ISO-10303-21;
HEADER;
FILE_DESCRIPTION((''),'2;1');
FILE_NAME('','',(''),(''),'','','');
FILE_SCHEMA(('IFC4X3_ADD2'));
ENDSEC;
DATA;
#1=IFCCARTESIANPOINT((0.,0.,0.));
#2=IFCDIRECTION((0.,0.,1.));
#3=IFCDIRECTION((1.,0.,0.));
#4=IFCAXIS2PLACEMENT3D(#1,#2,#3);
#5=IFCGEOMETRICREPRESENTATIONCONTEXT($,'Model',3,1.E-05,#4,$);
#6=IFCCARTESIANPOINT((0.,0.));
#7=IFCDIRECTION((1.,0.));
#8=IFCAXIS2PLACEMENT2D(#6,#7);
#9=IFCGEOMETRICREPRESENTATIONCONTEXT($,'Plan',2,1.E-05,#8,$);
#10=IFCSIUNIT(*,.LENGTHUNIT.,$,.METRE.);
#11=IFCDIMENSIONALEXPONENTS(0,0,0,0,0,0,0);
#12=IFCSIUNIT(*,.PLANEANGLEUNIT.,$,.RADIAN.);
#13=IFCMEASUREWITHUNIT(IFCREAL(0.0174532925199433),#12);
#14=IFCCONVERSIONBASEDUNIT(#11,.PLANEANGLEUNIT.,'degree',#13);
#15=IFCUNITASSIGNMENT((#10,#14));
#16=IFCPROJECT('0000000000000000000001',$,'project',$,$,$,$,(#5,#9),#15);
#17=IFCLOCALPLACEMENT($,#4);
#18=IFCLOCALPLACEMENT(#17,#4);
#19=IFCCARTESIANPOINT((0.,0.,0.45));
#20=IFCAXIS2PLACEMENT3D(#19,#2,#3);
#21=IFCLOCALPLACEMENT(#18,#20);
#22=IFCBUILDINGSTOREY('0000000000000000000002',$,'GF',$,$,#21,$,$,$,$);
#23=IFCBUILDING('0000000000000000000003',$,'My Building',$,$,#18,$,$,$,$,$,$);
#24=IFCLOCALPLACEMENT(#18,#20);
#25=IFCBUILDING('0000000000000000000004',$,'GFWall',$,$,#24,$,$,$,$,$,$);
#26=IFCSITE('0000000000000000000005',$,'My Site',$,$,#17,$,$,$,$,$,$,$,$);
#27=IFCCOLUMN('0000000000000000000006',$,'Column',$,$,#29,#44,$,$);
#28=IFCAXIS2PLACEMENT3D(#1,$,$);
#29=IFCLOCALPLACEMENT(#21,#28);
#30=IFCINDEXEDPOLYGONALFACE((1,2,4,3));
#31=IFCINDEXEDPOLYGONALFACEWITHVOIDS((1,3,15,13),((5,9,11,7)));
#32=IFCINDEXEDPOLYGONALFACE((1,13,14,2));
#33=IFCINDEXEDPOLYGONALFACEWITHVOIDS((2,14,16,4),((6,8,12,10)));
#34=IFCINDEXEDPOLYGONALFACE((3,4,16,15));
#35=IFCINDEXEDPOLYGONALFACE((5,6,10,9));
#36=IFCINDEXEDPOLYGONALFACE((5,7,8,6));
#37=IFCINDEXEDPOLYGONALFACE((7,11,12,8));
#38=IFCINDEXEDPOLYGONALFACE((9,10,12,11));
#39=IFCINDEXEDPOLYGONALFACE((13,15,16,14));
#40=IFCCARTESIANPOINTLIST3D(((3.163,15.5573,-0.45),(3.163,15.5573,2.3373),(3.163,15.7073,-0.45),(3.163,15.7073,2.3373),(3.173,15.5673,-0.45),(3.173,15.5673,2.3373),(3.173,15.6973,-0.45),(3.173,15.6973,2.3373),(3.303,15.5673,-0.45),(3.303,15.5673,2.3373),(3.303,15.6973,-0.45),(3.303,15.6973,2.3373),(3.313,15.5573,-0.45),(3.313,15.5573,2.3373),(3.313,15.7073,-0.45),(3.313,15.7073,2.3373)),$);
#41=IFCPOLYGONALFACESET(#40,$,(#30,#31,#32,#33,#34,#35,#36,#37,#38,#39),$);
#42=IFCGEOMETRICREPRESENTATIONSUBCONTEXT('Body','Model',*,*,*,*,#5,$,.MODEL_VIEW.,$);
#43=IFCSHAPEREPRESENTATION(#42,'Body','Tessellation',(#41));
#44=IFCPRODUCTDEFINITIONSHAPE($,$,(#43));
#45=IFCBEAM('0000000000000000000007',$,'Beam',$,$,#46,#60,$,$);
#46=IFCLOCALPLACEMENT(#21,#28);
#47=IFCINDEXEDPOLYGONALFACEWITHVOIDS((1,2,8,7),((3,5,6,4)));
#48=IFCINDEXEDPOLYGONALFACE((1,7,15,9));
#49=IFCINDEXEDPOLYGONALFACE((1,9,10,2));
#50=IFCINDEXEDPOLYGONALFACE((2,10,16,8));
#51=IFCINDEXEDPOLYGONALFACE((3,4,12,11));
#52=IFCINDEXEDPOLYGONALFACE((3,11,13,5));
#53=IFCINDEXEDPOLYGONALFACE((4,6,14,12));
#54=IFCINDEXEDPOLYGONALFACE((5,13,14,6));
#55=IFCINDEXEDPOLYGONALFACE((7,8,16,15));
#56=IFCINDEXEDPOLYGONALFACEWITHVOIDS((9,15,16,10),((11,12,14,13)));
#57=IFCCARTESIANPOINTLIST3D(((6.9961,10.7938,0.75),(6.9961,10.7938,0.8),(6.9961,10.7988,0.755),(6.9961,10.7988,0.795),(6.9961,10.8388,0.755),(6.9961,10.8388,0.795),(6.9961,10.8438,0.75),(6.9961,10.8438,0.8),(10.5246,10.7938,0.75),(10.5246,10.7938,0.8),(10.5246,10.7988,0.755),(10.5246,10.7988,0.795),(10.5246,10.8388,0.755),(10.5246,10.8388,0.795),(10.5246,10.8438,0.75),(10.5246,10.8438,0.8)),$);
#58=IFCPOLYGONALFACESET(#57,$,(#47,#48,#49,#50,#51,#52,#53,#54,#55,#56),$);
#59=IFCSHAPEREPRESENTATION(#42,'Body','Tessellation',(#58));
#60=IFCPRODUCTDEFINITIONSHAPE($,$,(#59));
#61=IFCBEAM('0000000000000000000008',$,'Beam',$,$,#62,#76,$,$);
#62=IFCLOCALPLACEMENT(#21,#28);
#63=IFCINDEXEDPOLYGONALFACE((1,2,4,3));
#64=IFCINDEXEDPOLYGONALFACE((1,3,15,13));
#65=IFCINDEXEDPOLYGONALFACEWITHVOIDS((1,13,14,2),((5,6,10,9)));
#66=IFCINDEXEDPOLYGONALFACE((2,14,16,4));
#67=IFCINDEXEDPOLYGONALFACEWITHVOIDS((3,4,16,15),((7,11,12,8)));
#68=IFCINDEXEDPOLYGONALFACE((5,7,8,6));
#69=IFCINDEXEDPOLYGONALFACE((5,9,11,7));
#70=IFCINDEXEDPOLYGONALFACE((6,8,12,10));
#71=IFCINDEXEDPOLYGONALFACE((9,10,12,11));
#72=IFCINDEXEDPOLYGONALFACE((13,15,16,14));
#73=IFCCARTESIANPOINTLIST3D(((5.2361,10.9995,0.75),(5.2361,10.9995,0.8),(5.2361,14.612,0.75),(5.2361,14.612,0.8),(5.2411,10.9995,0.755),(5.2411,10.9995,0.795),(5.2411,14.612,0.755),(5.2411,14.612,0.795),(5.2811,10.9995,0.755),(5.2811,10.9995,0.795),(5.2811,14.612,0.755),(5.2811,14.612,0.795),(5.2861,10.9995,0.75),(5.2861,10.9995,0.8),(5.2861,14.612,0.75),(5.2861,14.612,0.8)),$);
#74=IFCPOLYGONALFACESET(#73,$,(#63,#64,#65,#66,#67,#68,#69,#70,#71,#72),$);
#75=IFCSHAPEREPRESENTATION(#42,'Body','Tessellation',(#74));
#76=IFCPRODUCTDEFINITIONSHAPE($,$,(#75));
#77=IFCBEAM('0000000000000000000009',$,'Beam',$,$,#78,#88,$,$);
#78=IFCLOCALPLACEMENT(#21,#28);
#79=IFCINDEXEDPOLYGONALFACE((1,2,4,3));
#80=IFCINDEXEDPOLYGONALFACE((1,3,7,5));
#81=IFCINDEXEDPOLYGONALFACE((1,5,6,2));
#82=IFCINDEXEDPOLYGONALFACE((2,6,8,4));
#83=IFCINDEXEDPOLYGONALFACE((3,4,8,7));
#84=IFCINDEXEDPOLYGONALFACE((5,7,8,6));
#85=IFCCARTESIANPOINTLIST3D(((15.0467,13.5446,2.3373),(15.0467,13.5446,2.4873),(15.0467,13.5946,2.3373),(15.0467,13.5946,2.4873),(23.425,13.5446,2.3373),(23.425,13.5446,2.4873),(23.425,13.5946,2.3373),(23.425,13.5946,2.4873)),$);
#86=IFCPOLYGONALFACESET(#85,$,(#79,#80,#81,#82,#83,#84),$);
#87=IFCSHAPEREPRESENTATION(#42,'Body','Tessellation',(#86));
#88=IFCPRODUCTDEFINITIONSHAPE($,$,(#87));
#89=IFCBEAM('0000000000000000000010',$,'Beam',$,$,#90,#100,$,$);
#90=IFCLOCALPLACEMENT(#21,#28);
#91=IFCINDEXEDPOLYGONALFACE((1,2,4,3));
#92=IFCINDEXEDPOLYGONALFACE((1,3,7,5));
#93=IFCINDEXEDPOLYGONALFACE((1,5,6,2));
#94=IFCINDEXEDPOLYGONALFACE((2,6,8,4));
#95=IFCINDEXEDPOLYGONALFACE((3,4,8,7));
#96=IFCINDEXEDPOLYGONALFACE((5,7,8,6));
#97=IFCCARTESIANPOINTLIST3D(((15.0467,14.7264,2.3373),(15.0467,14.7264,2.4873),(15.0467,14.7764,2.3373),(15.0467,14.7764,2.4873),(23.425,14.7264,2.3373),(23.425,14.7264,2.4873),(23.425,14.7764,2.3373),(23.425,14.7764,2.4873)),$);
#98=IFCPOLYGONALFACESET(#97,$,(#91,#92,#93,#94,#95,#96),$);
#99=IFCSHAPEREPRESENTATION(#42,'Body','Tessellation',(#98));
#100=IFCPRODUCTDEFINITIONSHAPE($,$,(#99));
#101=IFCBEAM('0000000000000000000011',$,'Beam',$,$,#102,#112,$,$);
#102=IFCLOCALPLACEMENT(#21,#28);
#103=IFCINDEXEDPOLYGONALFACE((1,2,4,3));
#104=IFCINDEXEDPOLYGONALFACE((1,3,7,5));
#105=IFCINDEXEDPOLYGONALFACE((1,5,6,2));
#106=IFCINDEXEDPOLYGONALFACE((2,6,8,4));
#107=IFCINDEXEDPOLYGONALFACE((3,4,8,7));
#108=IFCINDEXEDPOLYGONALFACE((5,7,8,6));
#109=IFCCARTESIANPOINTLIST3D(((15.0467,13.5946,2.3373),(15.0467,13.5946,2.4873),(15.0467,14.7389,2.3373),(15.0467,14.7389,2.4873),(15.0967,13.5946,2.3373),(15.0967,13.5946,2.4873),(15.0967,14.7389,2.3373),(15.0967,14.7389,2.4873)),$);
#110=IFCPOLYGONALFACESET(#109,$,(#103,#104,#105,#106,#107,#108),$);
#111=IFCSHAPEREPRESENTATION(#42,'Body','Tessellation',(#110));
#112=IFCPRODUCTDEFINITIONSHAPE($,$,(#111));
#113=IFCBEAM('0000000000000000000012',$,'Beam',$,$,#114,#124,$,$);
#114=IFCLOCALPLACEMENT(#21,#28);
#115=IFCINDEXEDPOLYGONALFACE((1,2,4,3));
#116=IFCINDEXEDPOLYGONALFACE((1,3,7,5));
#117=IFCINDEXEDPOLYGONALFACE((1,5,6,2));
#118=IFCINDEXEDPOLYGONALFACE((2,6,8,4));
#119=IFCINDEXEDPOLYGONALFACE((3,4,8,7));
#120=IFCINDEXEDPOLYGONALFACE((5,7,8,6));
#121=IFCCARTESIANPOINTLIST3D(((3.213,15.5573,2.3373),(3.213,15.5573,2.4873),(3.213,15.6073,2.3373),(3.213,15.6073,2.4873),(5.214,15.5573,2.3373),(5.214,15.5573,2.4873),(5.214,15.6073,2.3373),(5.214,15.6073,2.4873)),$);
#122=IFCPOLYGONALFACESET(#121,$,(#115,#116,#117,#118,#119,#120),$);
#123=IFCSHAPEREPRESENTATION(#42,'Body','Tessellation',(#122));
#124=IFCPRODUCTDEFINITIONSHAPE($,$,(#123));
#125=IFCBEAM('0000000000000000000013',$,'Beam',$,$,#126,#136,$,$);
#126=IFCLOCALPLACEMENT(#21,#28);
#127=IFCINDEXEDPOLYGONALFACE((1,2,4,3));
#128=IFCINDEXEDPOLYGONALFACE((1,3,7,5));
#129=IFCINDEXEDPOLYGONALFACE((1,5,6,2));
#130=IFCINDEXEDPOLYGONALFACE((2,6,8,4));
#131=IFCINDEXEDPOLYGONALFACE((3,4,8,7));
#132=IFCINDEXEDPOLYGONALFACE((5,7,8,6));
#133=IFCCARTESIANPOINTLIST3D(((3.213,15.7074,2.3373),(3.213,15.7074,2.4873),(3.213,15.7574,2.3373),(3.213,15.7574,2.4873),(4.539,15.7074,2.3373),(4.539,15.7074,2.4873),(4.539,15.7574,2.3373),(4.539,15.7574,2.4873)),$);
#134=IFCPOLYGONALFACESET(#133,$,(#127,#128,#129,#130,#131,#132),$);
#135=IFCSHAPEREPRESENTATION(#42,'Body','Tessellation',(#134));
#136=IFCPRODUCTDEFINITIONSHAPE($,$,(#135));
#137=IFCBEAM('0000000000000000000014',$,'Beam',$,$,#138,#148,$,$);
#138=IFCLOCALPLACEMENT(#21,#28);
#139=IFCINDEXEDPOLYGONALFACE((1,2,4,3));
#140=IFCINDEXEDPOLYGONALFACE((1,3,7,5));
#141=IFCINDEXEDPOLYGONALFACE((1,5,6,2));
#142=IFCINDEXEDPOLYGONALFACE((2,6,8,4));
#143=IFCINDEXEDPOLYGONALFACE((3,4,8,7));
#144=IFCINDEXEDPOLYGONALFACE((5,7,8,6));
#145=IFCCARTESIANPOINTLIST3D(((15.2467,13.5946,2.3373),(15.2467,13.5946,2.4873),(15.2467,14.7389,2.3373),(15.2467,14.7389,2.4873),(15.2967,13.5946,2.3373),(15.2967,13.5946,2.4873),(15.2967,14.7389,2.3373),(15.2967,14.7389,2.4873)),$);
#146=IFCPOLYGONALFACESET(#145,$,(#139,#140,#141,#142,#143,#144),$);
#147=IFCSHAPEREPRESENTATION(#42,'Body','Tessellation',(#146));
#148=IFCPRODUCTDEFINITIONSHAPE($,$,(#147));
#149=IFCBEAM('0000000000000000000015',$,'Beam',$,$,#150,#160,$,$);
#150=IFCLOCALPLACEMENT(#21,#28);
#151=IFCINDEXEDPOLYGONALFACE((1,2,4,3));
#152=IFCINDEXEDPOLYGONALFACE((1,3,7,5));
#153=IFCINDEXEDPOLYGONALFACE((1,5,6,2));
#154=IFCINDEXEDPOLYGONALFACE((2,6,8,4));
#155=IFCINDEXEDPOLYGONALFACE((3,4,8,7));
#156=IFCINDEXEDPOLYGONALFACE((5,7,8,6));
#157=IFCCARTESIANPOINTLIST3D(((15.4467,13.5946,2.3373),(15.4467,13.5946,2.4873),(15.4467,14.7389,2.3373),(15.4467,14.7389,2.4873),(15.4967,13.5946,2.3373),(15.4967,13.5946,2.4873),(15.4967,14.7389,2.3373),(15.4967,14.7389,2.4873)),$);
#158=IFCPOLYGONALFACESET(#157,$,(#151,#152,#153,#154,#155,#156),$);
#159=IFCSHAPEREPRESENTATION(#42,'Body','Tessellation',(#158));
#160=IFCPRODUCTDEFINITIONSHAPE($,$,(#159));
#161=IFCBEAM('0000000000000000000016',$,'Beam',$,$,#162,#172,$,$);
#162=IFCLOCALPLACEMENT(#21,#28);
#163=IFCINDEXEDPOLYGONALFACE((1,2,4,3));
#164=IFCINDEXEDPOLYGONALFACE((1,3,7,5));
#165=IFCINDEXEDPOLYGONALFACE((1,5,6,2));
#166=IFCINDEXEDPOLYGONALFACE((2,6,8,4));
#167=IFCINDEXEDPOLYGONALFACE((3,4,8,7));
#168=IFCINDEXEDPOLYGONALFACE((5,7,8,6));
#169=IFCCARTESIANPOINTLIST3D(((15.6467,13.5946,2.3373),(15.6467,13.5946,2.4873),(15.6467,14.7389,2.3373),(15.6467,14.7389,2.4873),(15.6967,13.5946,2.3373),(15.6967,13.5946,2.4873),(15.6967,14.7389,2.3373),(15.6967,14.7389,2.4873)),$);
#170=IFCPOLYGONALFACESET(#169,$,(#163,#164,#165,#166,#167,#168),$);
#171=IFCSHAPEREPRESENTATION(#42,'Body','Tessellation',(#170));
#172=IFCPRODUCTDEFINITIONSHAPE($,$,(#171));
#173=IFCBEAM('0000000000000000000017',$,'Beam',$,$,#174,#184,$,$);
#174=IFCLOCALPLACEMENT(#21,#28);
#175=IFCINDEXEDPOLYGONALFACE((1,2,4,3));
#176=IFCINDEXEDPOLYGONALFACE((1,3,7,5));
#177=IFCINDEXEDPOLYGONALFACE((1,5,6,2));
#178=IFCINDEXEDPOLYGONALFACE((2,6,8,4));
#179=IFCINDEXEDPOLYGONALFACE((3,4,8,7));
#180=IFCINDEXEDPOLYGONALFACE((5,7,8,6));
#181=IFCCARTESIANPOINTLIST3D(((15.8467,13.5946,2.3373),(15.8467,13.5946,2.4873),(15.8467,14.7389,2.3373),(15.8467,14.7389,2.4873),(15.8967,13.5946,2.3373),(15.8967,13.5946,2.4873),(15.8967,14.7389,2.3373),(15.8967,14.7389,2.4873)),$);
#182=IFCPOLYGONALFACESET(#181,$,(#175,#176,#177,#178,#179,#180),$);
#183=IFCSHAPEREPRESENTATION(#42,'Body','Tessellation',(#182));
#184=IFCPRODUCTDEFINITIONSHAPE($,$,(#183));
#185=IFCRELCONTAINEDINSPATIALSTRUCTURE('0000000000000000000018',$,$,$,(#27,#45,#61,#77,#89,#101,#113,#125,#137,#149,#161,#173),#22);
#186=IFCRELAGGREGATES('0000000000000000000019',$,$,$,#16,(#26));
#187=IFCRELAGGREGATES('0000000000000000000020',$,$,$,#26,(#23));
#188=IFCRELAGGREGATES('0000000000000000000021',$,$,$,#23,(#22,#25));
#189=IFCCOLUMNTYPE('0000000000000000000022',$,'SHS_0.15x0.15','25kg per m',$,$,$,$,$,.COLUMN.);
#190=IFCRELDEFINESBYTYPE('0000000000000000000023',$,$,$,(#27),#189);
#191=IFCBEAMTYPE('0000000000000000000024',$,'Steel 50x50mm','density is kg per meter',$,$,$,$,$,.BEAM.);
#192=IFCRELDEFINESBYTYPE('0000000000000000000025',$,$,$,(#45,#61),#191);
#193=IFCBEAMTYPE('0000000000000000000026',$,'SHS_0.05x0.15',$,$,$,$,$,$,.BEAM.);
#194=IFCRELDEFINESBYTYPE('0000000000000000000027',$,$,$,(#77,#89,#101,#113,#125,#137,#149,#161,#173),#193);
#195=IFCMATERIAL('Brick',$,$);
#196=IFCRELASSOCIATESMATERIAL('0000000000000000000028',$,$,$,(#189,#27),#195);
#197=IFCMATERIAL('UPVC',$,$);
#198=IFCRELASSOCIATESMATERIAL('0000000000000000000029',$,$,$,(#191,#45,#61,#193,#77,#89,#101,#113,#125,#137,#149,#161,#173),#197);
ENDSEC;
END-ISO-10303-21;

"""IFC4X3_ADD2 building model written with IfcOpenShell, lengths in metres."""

from ifc_helpers import new_model, entity, si_unit, converted_unit, frame, origin_with_axes, origin_2d_with_axis, place, context, subcontext, project, spatial, rectangle, hollow_rectangle, extrude, shape, material, material_profile, profile_set, profile_usage, type_object, element, save


model = new_model("IFC4X3_ADD2")

# Units and contexts
model_context = context("Model", 3, precision=1e-05, world=origin_with_axes())
plan_context = context("Plan", 2, precision=1e-05, world=origin_2d_with_axis())
body_context_1 = subcontext(model_context, "Body", "Model", "MODEL_VIEW")
body_context_2 = subcontext(plan_context, "Body", "Plan", "PLAN_VIEW")
ifc_project = project(units=[si_unit("LENGTHUNIT", "METRE"), converted_unit("PLANEANGLEUNIT", "degree", entity("IfcReal", 0.0174532925199433), si_unit("PLANEANGLEUNIT", "RADIAN"), dimensions=[0, 0, 0, 0, 0, 0, 0])], contexts=[model_context, plan_context])

# Site, building, storey
site_placement = place(None, origin_with_axes())
site = spatial("IfcSite", under=ifc_project, at=site_placement, Name="My Site")
building_1_placement = place(site_placement, origin_with_axes())
building_1 = spatial("IfcBuilding", under=site, at=building_1_placement, Name="My Building")
storey_placement = place(building_1_placement, frame((0.0, 0.0, 0.45), z_axis=(0.0, 0.0, 1.0), x_axis=(1.0, 0.0, 0.0)))
storey = spatial("IfcBuildingStorey", under=building_1, at=storey_placement, Name="GF")

# Column
ifc_material_1 = material(Name="Brick")
ifc_material_profile_1 = material_profile(ifc_material_1, hollow_rectangle(XDim=0.15, YDim=0.15, WallThickness=0.01))
ifc_profile_set_1 = profile_set([ifc_material_profile_1])
ifc_profile_usage_1 = profile_usage(ifc_profile_set_1, cardinal=5)
column_type_1 = type_object("IfcColumnType", Name="SHS_0.15x0.15", Description="25kg per m", PredefinedType="COLUMN", material=ifc_profile_set_1)
column_1_placement = place(storey_placement, frame((3.238, 15.6323, -0.45), z_axis=(0.0, 0.0, 1.0), x_axis=(1.0, 0.0, 0.0)))
element("IfcColumn", 1, at=column_1_placement, inside=storey, type_object=column_type_1, material=ifc_profile_usage_1, Name="Column", shapes=[
    shape(body_context_1, "Body", "SweptSolid", [extrude(hollow_rectangle(XDim=0.15, YDim=0.15, WallThickness=0.01), origin_with_axes(), (0.0, 0.0, 1.0), 2.7873)]),
    shape(body_context_2, "Body", "Annotation2D", [entity("IfcGeometricCurveSet", [entity("IfcIndexedPolyCurve", entity("IfcCartesianPointList2D", [[0.075, -0.075], [-0.075, -0.075], [-0.075, 0.075], [0.075, 0.075]]), [entity("IfcLineIndex", [1, 2, 3, 4, 1])]), entity("IfcIndexedPolyCurve", entity("IfcCartesianPointList2D", [[-0.065, -0.065], [0.065, -0.065], [0.065, 0.065], [-0.065, 0.065]]), [entity("IfcLineIndex", [1, 2, 3, 4, 1])])])]),
])

# Beams
ifc_material_2 = material(Name="UPVC")
ifc_material_profile_2 = material_profile(ifc_material_2, hollow_rectangle(XDim=0.05, YDim=0.05, WallThickness=0.005))
ifc_profile_set_2 = profile_set([ifc_material_profile_2])
ifc_profile_usage_2 = profile_usage(ifc_profile_set_2)
beam_type_1 = type_object("IfcBeamType", Name="Steel 50x50mm", Description="density is kg per meter", PredefinedType="BEAM", material=ifc_profile_set_2)
beam_1_placement = place(storey_placement, frame((10.5246, 10.8188, 0.775), z_axis=(-1.0, 0.0, 0.0), x_axis=(0.0, -1.0, 0.0)))
element("IfcBeam", 2, at=beam_1_placement, inside=storey, type_object=beam_type_1, material=ifc_profile_usage_2, Name="Beam", context=body_context_1, shape_type="SweptSolid", body=[
    extrude(hollow_rectangle(XDim=0.05, YDim=0.05, WallThickness=0.005), origin_with_axes(), (0.0, 0.0, 1.0), 3.5286),
])
ifc_profile_usage_3 = profile_usage(ifc_profile_set_2)
beam_2_placement = place(storey_placement, frame((5.2611, 14.612, 0.775), z_axis=(0.0, -1.0, 0.0), x_axis=(1.0, 0.0, 0.0)))
element("IfcBeam", 3, at=beam_2_placement, inside=storey, type_object=beam_type_1, material=ifc_profile_usage_3, Name="Beam", context=body_context_1, shape_type="SweptSolid", body=[
    extrude(hollow_rectangle(XDim=0.05, YDim=0.05, WallThickness=0.005), origin_with_axes(), (0.0, 0.0, 1.0), 3.6125),
])
ifc_material_profile_3 = material_profile(ifc_material_2, rectangle(XDim=0.05, YDim=0.15))
ifc_profile_set_3 = profile_set([ifc_material_profile_3])
ifc_profile_usage_4 = profile_usage(ifc_profile_set_3)
beam_type_2 = type_object("IfcBeamType", Name="SHS_0.05x0.15", PredefinedType="BEAM", material=ifc_profile_set_3)
beam_3_placement = place(storey_placement, frame((15.0467, 13.5696, 2.4123), z_axis=(1.0, 0.0, 0.0), x_axis=(0.0, 1.0, 0.0)))
element("IfcBeam", 4, at=beam_3_placement, inside=storey, type_object=beam_type_2, material=ifc_profile_usage_4, Name="Beam", context=body_context_1, shape_type="SweptSolid", body=[
    extrude(rectangle(XDim=0.05, YDim=0.15), origin_with_axes(), (0.0, 0.0, 1.0), 8.3783),
])
ifc_profile_usage_5 = profile_usage(ifc_profile_set_3)
beam_4_placement = place(storey_placement, frame((15.0467, 14.7514, 2.4123), z_axis=(1.0, 0.0, 0.0), x_axis=(0.0, 1.0, 0.0)))
element("IfcBeam", 5, at=beam_4_placement, inside=storey, type_object=beam_type_2, material=ifc_profile_usage_5, Name="Beam", context=body_context_1, shape_type="SweptSolid", body=[
    extrude(rectangle(XDim=0.05, YDim=0.15), origin_with_axes(), (0.0, 0.0, 1.0), 8.3783),
])
ifc_profile_usage_6 = profile_usage(ifc_profile_set_3)
beam_5_placement = place(storey_placement, frame((15.0717, 14.7389, 2.4123), z_axis=(0.0, -1.0, 0.0), x_axis=(1.0, 0.0, 0.0)))
element("IfcBeam", 6, at=beam_5_placement, inside=storey, type_object=beam_type_2, material=ifc_profile_usage_6, Name="Beam", context=body_context_1, shape_type="SweptSolid", body=[
    extrude(rectangle(XDim=0.05, YDim=0.15), origin_with_axes(), (0.0, 0.0, 1.0), 1.1444),
])
ifc_profile_usage_7 = profile_usage(ifc_profile_set_3)
beam_6_placement = place(storey_placement, frame((3.213, 15.5823, 2.4123), z_axis=(1.0, 0.0, 0.0), x_axis=(0.0, 1.0, 0.0)))
element("IfcBeam", 7, at=beam_6_placement, inside=storey, type_object=beam_type_2, material=ifc_profile_usage_7, Name="Beam", context=body_context_1, shape_type="SweptSolid", body=[
    extrude(rectangle(XDim=0.05, YDim=0.15), origin_with_axes(), (0.0, 0.0, 1.0), 2.001),
])
ifc_profile_usage_8 = profile_usage(ifc_profile_set_3)
beam_7_placement = place(storey_placement, frame((3.213, 15.7324, 2.4123), z_axis=(1.0, 0.0, 0.0), x_axis=(0.0, 1.0, 0.0)))
element("IfcBeam", 8, at=beam_7_placement, inside=storey, type_object=beam_type_2, material=ifc_profile_usage_8, Name="Beam", context=body_context_1, shape_type="SweptSolid", body=[
    extrude(rectangle(XDim=0.05, YDim=0.15), origin_with_axes(), (0.0, 0.0, 1.0), 1.326),
])
ifc_profile_usage_9 = profile_usage(ifc_profile_set_3)
beam_8_placement = place(storey_placement, frame((15.2717, 14.7389, 2.4123), z_axis=(0.0, -1.0, 0.0), x_axis=(1.0, 0.0, 0.0)))
element("IfcBeam", 9, at=beam_8_placement, inside=storey, type_object=beam_type_2, material=ifc_profile_usage_9, Name="Beam", context=body_context_1, shape_type="SweptSolid", body=[
    extrude(rectangle(XDim=0.05, YDim=0.15), origin_with_axes(), (0.0, 0.0, 1.0), 1.1444),
])
ifc_profile_usage_10 = profile_usage(ifc_profile_set_3)
beam_9_placement = place(storey_placement, frame((15.4717, 14.7389, 2.4123), z_axis=(0.0, -1.0, 0.0), x_axis=(1.0, 0.0, 0.0)))
element("IfcBeam", 10, at=beam_9_placement, inside=storey, type_object=beam_type_2, material=ifc_profile_usage_10, Name="Beam", context=body_context_1, shape_type="SweptSolid", body=[
    extrude(rectangle(XDim=0.05, YDim=0.15), origin_with_axes(), (0.0, 0.0, 1.0), 1.1444),
])
ifc_profile_usage_11 = profile_usage(ifc_profile_set_3)
beam_10_placement = place(storey_placement, frame((15.6717, 14.7389, 2.4123), z_axis=(0.0, -1.0, 0.0), x_axis=(1.0, 0.0, 0.0)))
element("IfcBeam", 11, at=beam_10_placement, inside=storey, type_object=beam_type_2, material=ifc_profile_usage_11, Name="Beam", context=body_context_1, shape_type="SweptSolid", body=[
    extrude(rectangle(XDim=0.05, YDim=0.15), origin_with_axes(), (0.0, 0.0, 1.0), 1.1444),
])
ifc_profile_usage_12 = profile_usage(ifc_profile_set_3)
beam_11_placement = place(storey_placement, frame((15.8717, 14.7389, 2.4123), z_axis=(0.0, -1.0, 0.0), x_axis=(1.0, 0.0, 0.0)))
element("IfcBeam", 12, at=beam_11_placement, inside=storey, type_object=beam_type_2, material=ifc_profile_usage_12, Name="Beam", context=body_context_1, shape_type="SweptSolid", body=[
    extrude(rectangle(XDim=0.05, YDim=0.15), origin_with_axes(), (0.0, 0.0, 1.0), 1.1444),
])

# Shared definitions
building_2_placement = place(building_1_placement, frame((0.0, 0.0, 0.45), z_axis=(0.0, 0.0, 1.0), x_axis=(1.0, 0.0, 0.0)))
building_2 = spatial("IfcBuilding", under=building_1, at=building_2_placement, Name="GFWall")

save(model, "model.ifc")
